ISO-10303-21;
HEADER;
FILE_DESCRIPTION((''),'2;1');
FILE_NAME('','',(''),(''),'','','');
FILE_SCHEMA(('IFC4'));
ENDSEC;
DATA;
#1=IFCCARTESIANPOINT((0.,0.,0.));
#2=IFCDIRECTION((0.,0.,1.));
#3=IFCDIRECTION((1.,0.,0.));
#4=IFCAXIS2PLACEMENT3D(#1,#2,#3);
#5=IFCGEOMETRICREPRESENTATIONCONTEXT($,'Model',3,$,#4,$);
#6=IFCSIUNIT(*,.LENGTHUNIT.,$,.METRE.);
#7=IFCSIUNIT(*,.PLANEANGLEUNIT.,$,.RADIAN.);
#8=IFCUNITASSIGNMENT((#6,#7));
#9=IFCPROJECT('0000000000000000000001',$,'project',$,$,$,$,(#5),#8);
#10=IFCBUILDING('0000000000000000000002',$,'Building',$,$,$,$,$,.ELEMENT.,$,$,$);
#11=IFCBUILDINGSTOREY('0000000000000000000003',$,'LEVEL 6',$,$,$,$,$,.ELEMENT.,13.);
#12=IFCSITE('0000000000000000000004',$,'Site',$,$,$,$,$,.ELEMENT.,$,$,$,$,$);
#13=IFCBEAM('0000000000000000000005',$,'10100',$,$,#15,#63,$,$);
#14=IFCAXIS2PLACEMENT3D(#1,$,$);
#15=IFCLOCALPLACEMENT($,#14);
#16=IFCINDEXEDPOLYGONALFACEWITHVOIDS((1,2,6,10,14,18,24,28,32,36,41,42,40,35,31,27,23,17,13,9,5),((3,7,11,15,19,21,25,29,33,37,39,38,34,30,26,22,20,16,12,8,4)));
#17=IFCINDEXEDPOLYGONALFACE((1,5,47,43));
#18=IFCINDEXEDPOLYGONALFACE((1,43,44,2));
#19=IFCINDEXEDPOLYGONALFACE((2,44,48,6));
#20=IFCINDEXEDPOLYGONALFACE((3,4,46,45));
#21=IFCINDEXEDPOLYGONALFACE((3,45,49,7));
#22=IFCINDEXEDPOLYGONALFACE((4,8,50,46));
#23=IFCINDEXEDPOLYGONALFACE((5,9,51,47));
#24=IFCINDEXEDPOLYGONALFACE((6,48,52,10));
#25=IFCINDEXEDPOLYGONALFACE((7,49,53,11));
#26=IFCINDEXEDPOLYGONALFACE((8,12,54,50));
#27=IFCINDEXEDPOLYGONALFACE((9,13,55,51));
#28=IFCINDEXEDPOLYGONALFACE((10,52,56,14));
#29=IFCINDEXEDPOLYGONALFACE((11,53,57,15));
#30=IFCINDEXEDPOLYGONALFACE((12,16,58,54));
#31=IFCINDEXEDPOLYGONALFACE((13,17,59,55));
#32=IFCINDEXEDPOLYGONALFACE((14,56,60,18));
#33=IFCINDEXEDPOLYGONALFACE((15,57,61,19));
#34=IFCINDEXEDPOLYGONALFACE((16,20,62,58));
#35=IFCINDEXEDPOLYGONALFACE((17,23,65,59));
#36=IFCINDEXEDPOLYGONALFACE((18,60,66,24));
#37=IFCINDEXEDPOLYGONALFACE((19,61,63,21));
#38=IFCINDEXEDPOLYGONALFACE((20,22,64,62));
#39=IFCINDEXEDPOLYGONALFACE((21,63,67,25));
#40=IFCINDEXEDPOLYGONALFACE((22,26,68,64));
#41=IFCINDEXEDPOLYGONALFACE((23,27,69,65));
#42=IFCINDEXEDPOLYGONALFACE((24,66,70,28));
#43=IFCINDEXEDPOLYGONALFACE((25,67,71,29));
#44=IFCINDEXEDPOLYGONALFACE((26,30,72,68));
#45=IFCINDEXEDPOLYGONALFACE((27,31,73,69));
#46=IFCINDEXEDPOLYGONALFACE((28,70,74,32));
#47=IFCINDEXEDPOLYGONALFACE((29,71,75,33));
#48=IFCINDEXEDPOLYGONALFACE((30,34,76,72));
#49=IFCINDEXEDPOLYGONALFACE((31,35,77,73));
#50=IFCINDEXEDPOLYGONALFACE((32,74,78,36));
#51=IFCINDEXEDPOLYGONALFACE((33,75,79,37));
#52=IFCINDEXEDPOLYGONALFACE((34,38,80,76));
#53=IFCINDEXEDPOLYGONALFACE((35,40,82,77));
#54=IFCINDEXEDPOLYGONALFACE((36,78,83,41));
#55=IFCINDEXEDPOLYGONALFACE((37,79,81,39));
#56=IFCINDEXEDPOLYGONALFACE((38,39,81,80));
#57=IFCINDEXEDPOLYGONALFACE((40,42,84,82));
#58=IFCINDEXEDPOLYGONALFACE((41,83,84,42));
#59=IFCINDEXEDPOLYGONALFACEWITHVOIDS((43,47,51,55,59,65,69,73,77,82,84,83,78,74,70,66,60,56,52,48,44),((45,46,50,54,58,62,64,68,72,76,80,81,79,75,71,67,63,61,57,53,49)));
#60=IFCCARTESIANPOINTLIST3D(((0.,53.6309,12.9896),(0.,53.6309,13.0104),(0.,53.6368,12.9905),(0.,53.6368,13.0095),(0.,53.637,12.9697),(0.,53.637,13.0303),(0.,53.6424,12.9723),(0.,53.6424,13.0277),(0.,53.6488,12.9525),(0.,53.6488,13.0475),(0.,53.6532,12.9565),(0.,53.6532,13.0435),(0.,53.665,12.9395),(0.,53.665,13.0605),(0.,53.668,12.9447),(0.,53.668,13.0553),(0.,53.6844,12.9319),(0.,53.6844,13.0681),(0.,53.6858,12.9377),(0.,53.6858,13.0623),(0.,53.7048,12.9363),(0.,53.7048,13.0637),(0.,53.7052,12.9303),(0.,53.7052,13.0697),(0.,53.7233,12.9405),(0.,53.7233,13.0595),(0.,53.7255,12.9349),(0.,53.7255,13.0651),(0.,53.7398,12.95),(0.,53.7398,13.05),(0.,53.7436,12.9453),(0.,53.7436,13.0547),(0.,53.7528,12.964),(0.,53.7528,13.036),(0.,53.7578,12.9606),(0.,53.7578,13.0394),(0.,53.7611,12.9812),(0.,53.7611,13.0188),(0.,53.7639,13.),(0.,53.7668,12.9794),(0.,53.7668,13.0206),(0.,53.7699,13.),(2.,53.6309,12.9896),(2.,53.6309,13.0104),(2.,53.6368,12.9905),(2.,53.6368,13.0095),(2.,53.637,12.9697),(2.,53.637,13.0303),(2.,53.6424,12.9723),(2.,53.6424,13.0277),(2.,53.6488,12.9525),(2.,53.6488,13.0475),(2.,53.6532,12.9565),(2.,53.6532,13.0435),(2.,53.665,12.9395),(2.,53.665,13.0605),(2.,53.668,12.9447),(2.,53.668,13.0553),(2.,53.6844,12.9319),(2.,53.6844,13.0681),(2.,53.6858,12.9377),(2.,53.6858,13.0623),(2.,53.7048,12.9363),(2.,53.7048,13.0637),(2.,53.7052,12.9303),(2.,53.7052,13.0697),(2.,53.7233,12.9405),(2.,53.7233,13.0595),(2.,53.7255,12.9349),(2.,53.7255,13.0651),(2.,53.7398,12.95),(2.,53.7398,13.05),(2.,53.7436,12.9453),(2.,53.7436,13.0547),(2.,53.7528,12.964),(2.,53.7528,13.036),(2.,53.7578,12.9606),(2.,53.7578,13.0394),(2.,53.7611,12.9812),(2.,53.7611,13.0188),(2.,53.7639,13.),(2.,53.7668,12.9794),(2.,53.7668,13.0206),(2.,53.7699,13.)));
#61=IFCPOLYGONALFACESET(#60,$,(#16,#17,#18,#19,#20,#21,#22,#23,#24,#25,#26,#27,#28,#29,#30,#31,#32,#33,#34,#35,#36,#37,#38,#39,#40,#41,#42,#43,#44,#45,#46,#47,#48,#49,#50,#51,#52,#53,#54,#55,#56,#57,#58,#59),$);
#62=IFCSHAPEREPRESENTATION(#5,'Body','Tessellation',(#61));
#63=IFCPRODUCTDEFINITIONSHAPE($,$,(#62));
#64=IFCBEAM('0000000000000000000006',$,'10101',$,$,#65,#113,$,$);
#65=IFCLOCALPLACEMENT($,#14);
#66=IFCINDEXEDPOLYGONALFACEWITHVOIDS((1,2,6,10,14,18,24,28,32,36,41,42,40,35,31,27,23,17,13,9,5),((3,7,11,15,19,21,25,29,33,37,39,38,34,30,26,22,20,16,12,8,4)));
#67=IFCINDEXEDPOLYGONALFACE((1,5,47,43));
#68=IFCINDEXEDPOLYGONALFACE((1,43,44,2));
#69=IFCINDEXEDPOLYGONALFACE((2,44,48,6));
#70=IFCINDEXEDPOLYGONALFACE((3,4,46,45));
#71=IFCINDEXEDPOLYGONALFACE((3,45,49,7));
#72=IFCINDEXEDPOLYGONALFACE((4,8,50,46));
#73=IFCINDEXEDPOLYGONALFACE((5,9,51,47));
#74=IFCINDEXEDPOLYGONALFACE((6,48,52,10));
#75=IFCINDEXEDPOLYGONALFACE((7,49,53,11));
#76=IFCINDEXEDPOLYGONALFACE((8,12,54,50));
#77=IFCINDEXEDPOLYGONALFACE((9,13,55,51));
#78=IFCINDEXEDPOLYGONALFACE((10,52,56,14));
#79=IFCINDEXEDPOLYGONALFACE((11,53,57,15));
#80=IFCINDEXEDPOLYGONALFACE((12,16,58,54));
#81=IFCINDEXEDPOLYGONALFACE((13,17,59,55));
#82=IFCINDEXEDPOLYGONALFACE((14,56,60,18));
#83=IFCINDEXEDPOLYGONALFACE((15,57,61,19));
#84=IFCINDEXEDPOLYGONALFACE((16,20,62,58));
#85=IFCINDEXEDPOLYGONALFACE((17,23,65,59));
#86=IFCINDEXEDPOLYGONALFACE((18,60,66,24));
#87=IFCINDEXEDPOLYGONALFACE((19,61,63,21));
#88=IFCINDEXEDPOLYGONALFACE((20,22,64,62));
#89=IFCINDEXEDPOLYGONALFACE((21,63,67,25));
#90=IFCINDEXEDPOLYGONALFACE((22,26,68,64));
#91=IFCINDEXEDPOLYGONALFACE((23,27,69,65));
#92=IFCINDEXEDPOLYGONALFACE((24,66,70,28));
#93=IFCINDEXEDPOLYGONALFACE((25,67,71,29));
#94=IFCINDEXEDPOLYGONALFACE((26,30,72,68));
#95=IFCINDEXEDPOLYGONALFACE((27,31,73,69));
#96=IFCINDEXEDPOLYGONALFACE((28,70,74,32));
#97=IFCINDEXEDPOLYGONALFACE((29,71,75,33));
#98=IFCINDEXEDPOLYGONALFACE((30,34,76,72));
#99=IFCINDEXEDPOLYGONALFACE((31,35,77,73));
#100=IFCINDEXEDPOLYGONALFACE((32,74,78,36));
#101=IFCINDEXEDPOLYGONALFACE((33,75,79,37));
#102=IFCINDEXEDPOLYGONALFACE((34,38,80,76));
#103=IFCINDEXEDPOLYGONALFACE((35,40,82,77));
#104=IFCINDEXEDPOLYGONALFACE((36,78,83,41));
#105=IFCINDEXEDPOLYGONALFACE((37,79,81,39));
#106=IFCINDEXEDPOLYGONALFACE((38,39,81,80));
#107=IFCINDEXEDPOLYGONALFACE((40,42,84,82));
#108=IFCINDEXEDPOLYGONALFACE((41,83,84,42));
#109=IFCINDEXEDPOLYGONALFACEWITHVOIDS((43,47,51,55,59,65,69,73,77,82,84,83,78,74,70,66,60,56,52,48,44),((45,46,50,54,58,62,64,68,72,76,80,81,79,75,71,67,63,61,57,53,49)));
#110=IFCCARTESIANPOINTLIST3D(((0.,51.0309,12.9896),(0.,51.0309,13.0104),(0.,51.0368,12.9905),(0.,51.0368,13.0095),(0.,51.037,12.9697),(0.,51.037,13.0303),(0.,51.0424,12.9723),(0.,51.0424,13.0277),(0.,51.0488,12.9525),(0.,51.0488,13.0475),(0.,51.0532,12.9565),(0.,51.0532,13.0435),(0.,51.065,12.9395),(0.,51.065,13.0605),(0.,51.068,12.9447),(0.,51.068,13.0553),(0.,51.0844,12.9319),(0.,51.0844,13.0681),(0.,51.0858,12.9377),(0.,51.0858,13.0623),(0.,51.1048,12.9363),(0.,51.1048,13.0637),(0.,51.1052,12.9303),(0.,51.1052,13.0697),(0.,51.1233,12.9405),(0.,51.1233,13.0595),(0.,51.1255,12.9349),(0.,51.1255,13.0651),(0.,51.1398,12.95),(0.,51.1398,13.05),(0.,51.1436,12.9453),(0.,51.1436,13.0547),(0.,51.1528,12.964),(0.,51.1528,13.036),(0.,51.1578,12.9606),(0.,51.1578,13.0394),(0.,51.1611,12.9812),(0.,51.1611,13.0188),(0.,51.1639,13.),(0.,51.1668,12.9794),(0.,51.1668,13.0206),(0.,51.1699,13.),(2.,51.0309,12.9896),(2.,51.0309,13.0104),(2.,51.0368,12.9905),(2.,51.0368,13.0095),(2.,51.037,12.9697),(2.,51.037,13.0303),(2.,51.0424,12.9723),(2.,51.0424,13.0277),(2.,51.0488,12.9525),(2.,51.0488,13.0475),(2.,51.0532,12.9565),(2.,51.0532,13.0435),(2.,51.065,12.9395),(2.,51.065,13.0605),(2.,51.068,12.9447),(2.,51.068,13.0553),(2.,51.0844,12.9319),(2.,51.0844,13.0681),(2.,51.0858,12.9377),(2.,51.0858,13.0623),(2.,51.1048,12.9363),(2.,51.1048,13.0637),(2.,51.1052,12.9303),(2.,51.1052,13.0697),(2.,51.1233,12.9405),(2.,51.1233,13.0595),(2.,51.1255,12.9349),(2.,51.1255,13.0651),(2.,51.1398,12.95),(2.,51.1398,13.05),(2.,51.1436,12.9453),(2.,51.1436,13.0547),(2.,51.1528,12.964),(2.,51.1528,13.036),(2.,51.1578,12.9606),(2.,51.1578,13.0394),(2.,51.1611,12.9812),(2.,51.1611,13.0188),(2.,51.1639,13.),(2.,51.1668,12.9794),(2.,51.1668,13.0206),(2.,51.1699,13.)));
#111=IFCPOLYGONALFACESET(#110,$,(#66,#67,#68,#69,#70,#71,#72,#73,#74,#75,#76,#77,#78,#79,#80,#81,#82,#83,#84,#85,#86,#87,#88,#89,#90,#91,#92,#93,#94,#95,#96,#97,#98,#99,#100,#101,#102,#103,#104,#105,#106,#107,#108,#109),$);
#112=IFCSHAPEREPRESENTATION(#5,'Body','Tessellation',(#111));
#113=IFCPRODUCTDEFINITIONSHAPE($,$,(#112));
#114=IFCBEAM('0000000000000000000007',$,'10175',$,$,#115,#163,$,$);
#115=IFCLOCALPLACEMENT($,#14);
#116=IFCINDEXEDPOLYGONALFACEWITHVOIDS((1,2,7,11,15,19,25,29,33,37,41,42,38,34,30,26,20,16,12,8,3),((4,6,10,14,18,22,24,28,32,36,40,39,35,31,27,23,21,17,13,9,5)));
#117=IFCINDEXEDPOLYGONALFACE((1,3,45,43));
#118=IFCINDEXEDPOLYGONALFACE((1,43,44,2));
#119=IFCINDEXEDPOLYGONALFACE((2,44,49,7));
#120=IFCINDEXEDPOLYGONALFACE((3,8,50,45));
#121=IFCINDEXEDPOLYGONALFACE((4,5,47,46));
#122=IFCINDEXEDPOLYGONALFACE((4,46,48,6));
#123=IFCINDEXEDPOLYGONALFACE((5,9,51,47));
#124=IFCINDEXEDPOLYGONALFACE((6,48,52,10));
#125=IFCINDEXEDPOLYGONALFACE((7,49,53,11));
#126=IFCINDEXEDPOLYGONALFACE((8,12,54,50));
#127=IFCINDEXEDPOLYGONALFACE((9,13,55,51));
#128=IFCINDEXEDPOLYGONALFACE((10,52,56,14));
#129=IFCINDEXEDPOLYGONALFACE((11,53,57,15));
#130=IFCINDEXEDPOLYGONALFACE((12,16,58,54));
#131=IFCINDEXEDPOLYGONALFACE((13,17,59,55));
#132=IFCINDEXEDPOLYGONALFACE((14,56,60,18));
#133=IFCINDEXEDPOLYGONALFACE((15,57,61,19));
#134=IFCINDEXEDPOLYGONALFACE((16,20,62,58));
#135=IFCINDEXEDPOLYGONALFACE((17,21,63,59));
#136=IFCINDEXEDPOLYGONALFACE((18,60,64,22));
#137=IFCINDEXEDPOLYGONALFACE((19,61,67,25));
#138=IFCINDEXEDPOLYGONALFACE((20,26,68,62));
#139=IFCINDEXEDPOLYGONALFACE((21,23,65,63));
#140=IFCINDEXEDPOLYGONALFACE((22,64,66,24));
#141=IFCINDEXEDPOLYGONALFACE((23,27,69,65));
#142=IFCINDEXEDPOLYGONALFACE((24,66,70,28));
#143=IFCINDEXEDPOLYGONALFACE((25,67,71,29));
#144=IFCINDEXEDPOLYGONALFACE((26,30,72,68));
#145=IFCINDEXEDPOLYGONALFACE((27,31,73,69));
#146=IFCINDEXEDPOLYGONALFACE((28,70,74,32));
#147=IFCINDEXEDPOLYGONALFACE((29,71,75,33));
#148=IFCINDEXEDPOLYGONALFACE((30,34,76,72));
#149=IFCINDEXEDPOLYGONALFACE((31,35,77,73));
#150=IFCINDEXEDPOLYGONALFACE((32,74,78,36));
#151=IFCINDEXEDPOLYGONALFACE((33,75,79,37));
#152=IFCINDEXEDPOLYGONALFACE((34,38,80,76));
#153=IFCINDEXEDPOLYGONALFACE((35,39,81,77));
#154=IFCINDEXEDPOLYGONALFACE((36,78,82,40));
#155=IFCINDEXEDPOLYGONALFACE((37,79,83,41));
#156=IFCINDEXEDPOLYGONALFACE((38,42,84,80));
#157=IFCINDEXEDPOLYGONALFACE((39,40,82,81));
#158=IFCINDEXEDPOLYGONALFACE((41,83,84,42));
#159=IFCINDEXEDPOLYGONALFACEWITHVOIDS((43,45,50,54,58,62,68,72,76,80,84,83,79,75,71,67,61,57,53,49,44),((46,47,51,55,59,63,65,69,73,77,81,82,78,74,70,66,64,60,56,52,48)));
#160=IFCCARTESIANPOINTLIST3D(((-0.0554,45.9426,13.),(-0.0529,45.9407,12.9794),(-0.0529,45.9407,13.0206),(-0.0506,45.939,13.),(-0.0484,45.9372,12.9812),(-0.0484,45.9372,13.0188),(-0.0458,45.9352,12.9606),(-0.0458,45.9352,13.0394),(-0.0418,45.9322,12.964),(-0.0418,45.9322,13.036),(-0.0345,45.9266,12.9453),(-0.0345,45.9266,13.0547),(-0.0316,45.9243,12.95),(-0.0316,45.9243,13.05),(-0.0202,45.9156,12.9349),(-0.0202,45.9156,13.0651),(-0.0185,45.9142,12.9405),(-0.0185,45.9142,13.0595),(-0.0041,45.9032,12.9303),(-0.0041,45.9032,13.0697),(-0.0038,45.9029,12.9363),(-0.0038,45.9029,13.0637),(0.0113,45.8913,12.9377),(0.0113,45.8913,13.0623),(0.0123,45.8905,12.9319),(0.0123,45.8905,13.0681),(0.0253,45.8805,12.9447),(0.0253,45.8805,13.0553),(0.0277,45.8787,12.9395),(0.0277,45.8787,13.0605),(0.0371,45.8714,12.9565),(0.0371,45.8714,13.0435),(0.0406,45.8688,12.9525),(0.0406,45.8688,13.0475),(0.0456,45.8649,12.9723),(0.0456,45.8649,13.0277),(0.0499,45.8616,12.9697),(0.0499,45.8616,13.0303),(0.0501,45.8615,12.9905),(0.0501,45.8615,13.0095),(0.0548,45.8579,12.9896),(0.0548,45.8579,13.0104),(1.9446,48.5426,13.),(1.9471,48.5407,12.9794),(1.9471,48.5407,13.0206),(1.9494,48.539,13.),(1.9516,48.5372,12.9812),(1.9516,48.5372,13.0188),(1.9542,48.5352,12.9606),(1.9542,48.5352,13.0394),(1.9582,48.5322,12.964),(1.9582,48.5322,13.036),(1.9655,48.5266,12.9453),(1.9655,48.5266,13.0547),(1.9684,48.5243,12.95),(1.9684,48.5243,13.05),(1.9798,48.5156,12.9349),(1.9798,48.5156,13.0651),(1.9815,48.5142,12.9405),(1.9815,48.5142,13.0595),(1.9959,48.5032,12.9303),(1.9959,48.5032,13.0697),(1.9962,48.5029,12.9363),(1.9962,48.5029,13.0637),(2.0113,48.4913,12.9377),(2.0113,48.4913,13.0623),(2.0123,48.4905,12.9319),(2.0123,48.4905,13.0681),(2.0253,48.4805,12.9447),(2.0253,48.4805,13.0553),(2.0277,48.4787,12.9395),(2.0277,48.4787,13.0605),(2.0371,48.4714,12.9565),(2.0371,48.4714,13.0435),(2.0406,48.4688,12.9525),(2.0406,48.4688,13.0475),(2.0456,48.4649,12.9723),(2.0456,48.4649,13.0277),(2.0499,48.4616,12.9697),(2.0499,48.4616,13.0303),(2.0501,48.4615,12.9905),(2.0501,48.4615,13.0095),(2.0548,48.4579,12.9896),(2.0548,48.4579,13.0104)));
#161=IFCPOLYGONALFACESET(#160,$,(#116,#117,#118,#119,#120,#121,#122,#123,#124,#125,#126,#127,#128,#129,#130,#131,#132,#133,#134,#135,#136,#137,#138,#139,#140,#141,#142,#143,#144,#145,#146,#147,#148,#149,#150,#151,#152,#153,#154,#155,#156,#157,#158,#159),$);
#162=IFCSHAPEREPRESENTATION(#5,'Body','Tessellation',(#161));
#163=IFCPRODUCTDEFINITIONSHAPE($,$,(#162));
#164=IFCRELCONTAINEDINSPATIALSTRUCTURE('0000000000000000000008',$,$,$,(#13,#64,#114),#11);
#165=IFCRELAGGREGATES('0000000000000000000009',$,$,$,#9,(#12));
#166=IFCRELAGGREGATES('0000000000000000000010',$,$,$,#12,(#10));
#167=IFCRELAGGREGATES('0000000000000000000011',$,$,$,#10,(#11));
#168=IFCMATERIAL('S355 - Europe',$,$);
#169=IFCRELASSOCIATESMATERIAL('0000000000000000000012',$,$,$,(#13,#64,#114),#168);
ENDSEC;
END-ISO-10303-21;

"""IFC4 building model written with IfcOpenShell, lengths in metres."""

from ifc_helpers import new_model, si_unit, frame, origin_with_axes, origin_2d_with_axis, place, context, project, spatial, hollow_circle, extrude, material, material_profile, profile_set, profile_usage, element, save


model = new_model("IFC4")

# Units and contexts
model_context = context("Model", 3, world=origin_with_axes())
ifc_project = project(units=[si_unit("LENGTHUNIT", "METRE"), si_unit("PLANEANGLEUNIT", "RADIAN")], contexts=[model_context])

# Site, building, storey
site = spatial("IfcSite", under=ifc_project, Name="Site", CompositionType="ELEMENT")
building = spatial("IfcBuilding", under=site, Name="Building", CompositionType="ELEMENT")
storey = spatial("IfcBuildingStorey", under=building, Name="LEVEL 6", CompositionType="ELEMENT", Elevation=13.0)

# Shared definitions
ifc_material = material(Name="S355 - Europe")

# Beams
ifc_material_profile_1 = material_profile(ifc_material, hollow_circle(Radius=0.0699, WallThickness=0.006, at=origin_2d_with_axis()))
ifc_profile_set_1 = profile_set([ifc_material_profile_1])
ifc_profile_usage_1 = profile_usage(ifc_profile_set_1, cardinal=10)
beam_1_placement = place(None, frame((0.0, 53.7, 13.0), z_axis=(1.0, 0.0, 0.0), x_axis=(0.0, 1.0, 0.0)))
element("IfcBeam", 1, at=beam_1_placement, inside=storey, material=ifc_profile_usage_1, Name="10100", context=model_context, shape_type="SweptSolid", body=[
    extrude(hollow_circle(Radius=0.0699, WallThickness=0.006, at=origin_2d_with_axis()), origin_with_axes(), (0.0, 0.0, 1.0), 2.0),
])
ifc_material_profile_2 = material_profile(ifc_material, hollow_circle(Radius=0.0699, WallThickness=0.006, at=origin_2d_with_axis()))
ifc_profile_set_2 = profile_set([ifc_material_profile_2])
ifc_profile_usage_2 = profile_usage(ifc_profile_set_2, cardinal=10)
beam_2_placement = place(None, frame((0.0, 51.1, 13.0), z_axis=(1.0, 0.0, 0.0), x_axis=(0.0, 1.0, 0.0)))
element("IfcBeam", 2, at=beam_2_placement, inside=storey, material=ifc_profile_usage_2, Name="10101", context=model_context, shape_type="SweptSolid", body=[
    extrude(hollow_circle(Radius=0.0699, WallThickness=0.006, at=origin_2d_with_axis()), origin_with_axes(), (0.0, 0.0, 1.0), 2.0),
])
ifc_material_profile_3 = material_profile(ifc_material, hollow_circle(Radius=0.0699, WallThickness=0.006, at=origin_2d_with_axis()))
ifc_profile_set_3 = profile_set([ifc_material_profile_3])
ifc_profile_usage_3 = profile_usage(ifc_profile_set_3, cardinal=10)
beam_3_placement = place(None, frame((0.0, 45.9, 13.0), z_axis=(0.609711, 0.792624, 0.0), x_axis=(-0.792624, 0.609711, 0.0)))
element("IfcBeam", 3, at=beam_3_placement, inside=storey, material=ifc_profile_usage_3, Name="10175", context=model_context, shape_type="SweptSolid", body=[
    extrude(hollow_circle(Radius=0.0699, WallThickness=0.006, at=origin_2d_with_axis()), origin_with_axes(), (0.0, 0.0, 1.0), 3.2802),
])

save(model, "model.ifc")
